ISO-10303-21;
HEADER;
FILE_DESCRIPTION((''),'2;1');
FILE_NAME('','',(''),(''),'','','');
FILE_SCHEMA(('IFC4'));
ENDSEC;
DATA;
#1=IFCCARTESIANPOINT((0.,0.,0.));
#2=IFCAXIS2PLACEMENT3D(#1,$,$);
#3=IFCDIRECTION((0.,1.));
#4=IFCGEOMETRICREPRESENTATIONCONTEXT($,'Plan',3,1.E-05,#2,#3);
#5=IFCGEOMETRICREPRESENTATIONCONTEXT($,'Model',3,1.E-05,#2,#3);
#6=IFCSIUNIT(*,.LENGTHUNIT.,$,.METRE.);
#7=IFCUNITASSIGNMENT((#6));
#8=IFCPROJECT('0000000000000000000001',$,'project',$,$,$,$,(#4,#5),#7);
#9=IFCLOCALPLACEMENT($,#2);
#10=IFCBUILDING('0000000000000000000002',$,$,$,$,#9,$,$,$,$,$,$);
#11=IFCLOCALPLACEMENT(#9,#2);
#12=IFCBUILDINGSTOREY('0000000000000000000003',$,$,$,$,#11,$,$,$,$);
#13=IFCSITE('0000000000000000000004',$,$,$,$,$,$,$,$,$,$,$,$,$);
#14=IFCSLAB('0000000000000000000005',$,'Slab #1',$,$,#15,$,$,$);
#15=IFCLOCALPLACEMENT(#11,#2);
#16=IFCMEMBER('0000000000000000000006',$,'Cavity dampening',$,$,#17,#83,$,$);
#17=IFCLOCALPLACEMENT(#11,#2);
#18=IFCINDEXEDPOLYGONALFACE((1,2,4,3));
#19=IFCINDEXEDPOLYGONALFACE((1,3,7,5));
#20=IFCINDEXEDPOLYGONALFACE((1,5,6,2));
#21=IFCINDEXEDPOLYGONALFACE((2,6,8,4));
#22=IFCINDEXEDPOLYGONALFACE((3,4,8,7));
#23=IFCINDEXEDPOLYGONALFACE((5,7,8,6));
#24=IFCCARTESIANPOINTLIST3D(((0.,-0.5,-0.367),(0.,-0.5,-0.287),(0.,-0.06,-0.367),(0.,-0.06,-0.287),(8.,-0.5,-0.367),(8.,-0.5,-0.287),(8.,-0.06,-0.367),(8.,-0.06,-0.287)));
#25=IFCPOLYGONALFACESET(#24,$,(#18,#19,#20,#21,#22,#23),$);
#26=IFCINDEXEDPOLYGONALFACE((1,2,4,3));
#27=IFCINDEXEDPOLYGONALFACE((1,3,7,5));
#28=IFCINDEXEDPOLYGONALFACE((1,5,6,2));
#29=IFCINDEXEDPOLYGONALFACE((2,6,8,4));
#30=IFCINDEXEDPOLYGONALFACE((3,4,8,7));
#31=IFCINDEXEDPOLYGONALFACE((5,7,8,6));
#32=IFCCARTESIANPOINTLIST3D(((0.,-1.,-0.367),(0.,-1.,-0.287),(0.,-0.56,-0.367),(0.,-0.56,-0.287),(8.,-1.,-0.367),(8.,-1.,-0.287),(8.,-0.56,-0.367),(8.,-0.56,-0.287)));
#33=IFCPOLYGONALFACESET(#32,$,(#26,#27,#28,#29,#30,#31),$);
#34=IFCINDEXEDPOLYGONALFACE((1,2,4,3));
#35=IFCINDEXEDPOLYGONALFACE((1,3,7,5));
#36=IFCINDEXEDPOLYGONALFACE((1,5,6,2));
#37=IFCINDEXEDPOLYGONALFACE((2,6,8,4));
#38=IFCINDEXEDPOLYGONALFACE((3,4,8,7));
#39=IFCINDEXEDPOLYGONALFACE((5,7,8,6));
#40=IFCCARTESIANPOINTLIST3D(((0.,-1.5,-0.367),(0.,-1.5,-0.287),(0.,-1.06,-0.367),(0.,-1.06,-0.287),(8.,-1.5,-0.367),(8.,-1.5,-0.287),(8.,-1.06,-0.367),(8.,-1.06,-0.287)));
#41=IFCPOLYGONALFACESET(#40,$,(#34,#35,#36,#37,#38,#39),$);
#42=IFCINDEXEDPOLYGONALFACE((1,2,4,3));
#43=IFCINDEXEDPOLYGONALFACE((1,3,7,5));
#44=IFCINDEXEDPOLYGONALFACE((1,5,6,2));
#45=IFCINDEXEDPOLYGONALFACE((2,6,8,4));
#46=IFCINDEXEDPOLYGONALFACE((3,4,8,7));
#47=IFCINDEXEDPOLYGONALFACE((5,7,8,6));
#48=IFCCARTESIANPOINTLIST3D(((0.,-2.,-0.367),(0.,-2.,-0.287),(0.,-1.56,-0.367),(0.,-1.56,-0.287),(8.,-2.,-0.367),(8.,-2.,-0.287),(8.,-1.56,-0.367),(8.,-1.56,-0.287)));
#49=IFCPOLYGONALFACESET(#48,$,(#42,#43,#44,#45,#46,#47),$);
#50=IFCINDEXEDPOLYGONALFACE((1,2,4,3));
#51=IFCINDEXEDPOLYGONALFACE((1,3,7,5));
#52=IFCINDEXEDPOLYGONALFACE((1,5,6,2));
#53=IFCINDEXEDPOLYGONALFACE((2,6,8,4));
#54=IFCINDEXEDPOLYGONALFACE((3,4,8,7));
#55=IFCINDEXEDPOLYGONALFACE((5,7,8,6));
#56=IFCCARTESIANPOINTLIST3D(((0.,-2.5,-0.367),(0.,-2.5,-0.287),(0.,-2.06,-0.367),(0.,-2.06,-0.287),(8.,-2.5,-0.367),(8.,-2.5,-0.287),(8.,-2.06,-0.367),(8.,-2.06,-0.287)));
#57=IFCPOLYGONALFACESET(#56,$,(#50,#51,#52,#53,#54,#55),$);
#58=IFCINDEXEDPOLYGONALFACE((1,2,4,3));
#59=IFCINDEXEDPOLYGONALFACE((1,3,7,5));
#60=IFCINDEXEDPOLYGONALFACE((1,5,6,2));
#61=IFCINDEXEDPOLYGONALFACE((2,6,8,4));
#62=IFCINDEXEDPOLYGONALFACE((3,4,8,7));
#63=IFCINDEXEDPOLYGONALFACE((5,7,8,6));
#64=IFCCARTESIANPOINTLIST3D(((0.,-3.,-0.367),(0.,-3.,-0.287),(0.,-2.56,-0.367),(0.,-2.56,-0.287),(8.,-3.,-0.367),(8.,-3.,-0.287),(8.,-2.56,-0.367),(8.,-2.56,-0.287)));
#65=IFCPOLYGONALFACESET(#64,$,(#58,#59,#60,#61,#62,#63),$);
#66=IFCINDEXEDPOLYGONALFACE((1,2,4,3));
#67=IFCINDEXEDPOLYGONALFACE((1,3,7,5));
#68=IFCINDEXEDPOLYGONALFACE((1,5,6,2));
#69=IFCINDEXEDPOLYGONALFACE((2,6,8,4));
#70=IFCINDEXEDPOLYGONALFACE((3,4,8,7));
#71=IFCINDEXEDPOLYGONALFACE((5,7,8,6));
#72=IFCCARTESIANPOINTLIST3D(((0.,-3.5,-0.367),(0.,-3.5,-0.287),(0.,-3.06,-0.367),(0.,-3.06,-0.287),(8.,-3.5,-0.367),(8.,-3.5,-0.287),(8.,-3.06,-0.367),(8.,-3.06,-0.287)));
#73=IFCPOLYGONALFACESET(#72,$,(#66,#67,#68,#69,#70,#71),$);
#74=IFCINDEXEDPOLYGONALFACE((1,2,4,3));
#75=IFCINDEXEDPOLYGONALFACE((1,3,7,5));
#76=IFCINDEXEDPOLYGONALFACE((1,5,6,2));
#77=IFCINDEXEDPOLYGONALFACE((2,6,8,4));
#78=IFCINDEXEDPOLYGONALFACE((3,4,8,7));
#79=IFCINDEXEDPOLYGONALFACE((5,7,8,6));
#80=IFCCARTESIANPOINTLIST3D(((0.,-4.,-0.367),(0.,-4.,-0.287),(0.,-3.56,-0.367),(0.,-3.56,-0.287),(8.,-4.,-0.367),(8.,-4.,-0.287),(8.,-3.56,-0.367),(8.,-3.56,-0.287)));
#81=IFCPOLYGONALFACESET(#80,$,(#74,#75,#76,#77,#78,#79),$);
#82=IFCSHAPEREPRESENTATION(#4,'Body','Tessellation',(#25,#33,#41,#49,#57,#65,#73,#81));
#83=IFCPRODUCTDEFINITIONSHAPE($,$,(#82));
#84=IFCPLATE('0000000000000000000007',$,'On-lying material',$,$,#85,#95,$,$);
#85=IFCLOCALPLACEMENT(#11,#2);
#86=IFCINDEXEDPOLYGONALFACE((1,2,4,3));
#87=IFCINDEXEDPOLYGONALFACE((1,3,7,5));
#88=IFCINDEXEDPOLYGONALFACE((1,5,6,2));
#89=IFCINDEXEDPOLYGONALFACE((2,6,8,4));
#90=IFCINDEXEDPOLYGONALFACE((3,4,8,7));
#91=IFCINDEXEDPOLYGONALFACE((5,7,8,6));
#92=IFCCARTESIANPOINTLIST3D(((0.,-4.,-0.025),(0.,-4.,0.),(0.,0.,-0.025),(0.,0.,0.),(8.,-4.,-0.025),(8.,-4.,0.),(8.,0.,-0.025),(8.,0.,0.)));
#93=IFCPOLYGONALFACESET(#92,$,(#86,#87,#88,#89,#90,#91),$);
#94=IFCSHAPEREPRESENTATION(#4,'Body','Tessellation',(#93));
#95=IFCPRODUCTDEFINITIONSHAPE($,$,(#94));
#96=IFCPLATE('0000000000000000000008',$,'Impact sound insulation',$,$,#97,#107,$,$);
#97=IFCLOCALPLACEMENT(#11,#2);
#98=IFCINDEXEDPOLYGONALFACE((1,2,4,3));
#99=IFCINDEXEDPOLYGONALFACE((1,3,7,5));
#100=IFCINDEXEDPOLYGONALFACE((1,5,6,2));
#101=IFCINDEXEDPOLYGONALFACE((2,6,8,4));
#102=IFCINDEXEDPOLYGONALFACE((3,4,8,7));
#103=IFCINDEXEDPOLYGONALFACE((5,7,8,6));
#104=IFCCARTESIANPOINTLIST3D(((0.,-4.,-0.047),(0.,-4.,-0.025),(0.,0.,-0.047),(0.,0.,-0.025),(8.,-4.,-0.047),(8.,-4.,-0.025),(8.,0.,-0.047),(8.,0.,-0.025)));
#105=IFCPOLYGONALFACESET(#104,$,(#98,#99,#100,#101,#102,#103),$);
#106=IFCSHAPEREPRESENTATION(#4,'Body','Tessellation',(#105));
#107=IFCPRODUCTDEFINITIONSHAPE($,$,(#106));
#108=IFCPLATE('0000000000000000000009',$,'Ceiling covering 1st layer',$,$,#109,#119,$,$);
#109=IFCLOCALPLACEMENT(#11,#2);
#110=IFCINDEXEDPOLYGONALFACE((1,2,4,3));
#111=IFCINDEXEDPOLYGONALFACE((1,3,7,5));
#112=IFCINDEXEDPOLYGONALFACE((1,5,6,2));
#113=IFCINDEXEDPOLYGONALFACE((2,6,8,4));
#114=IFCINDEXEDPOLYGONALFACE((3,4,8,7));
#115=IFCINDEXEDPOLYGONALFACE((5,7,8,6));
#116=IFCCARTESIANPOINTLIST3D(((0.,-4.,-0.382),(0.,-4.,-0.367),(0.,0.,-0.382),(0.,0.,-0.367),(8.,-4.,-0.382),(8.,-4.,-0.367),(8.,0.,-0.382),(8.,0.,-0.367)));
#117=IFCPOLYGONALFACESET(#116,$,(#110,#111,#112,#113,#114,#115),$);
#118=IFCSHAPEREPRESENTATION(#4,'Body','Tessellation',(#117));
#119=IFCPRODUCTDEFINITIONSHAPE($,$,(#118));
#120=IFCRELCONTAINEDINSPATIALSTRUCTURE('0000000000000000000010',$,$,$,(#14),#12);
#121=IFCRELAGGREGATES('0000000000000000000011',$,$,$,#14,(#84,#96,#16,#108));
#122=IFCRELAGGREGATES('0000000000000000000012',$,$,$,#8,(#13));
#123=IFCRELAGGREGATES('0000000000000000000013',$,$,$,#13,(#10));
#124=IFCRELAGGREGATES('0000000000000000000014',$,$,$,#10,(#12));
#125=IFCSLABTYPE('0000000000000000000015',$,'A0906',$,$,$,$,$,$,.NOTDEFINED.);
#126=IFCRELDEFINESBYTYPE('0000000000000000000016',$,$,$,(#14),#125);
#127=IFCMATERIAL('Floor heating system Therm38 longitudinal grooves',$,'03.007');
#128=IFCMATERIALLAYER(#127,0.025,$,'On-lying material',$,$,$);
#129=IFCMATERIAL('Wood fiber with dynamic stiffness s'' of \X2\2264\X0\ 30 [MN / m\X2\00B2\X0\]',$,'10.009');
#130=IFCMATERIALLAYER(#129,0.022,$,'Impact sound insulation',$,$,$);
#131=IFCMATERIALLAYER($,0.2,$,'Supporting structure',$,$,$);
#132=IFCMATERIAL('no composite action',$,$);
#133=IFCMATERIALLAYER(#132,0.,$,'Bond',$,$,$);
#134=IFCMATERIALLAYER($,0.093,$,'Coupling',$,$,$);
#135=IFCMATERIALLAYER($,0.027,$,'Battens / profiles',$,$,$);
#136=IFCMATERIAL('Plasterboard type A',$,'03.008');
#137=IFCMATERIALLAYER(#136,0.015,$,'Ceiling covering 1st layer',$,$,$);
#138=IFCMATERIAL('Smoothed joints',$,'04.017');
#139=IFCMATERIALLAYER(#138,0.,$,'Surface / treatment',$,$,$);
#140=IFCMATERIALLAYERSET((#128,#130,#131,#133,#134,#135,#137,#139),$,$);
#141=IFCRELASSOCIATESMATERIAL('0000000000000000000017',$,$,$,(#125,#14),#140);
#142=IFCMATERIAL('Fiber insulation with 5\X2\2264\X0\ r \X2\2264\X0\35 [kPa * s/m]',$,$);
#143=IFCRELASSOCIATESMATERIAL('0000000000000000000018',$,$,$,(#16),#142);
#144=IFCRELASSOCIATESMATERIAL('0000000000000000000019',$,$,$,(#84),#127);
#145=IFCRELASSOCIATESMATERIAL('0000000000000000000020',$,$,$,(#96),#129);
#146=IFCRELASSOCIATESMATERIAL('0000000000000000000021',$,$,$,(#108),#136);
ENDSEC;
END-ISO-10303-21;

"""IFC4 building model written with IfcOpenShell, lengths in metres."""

from ifc_helpers import new_model, si_unit, direction, frame, frame_2d, origin, origin_with_axes, place, context, project, spatial, rectangle, extrude, material, layer, layer_set, type_object, element, aggregate, save


model = new_model("IFC4")

# Units and contexts
plan_context = context("Plan", 3, precision=1e-05, world=origin(), true_north=direction((0.0, 1.0)))
model_context = context("Model", 3, precision=1e-05, world=origin(), true_north=direction((0.0, 1.0)))
ifc_project = project(units=[si_unit("LENGTHUNIT", "METRE")], contexts=[plan_context, model_context])

# Site, building, storey
site = spatial("IfcSite", under=ifc_project)
building_placement = place(None, origin())
building = spatial("IfcBuilding", under=site, at=building_placement)
storey_placement = place(building_placement, origin())
storey = spatial("IfcBuildingStorey", under=building, at=storey_placement)

# Slab, member, plates
ifc_material_1 = material(Name="Floor heating system Therm38 longitudinal grooves", Category="03.007")
ifc_layer_1 = layer(ifc_material_1, 0.025, Name="On-lying material")
ifc_material_2 = material(Name="Wood fiber with dynamic stiffness s' of ≤ 30 [MN / m²]", Category="10.009")
ifc_layer_2 = layer(ifc_material_2, 0.022, Name="Impact sound insulation")
ifc_layer_3 = layer(None, 0.2, Name="Supporting structure")
ifc_material_3 = material(Name="no composite action")
ifc_layer_4 = layer(ifc_material_3, 0.0, Name="Bond")
ifc_layer_5 = layer(None, 0.093, Name="Coupling")
ifc_layer_6 = layer(None, 0.027, Name="Battens / profiles")
ifc_material_4 = material(Name="Plasterboard type A", Category="03.008")
ifc_layer_7 = layer(ifc_material_4, 0.015, Name="Ceiling covering 1st layer")
ifc_material_5 = material(Name="Smoothed joints", Category="04.017")
ifc_layer_8 = layer(ifc_material_5, 0.0, Name="Surface / treatment")
ifc_layer_set = layer_set([ifc_layer_1, ifc_layer_2, ifc_layer_3, ifc_layer_4, ifc_layer_5, ifc_layer_6, ifc_layer_7, ifc_layer_8])
slab_type = type_object("IfcSlabType", Name="A0906", PredefinedType="NOTDEFINED", material=ifc_layer_set)
slab_placement = place(None, frame((0.0, 0.0, 0.0), z_axis=(0.0, 0.0, -1.0), x_axis=(1.0, 0.0, 0.0)))
slab = element("IfcSlab", 1, at=slab_placement, inside=storey, type_object=slab_type, material=ifc_layer_set, Name="Slab #1")
ifc_material_6 = material(Name="Fiber insulation with 5≤ r ≤35 [kPa * s/m]")
member_1_placement = place(slab_placement, origin())
member_1 = element("IfcMember", 2, at=member_1_placement, material=ifc_material_6, Name="Cavity dampening", context=plan_context, shape_type="SweptSolid", body=[
    extrude(rectangle(XDim=0.44, YDim=0.08, at=frame_2d((0.22, 0.04), x_axis=(1.0, 0.0))), frame((0.0, 0.06, 0.287), z_axis=(1.0, 0.0, 0.0), x_axis=(0.0, 1.0, 0.0)), (0.0, 0.0, 1.0), 8.0),
    extrude(rectangle(XDim=0.44, YDim=0.08, at=frame_2d((0.22, 0.04), x_axis=(1.0, 0.0))), frame((0.0, 0.56, 0.287), z_axis=(1.0, 0.0, 0.0), x_axis=(0.0, 1.0, 0.0)), (0.0, 0.0, 1.0), 8.0),
    extrude(rectangle(XDim=0.44, YDim=0.08, at=frame_2d((0.22, 0.04), x_axis=(1.0, 0.0))), frame((0.0, 1.06, 0.287), z_axis=(1.0, 0.0, 0.0), x_axis=(0.0, 1.0, 0.0)), (0.0, 0.0, 1.0), 8.0),
    extrude(rectangle(XDim=0.44, YDim=0.08, at=frame_2d((0.22, 0.04), x_axis=(1.0, 0.0))), frame((0.0, 1.56, 0.287), z_axis=(1.0, 0.0, 0.0), x_axis=(0.0, 1.0, 0.0)), (0.0, 0.0, 1.0), 8.0),
    extrude(rectangle(XDim=0.44, YDim=0.08, at=frame_2d((0.22, 0.04), x_axis=(1.0, 0.0))), frame((0.0, 2.06, 0.287), z_axis=(1.0, 0.0, 0.0), x_axis=(0.0, 1.0, 0.0)), (0.0, 0.0, 1.0), 8.0),
    extrude(rectangle(XDim=0.44, YDim=0.08, at=frame_2d((0.22, 0.04), x_axis=(1.0, 0.0))), frame((0.0, 2.56, 0.287), z_axis=(1.0, 0.0, 0.0), x_axis=(0.0, 1.0, 0.0)), (0.0, 0.0, 1.0), 8.0),
    extrude(rectangle(XDim=0.44, YDim=0.08, at=frame_2d((0.22, 0.04), x_axis=(1.0, 0.0))), frame((0.0, 3.06, 0.287), z_axis=(1.0, 0.0, 0.0), x_axis=(0.0, 1.0, 0.0)), (0.0, 0.0, 1.0), 8.0),
    extrude(rectangle(XDim=0.44, YDim=0.08, at=frame_2d((0.22, 0.04), x_axis=(1.0, 0.0))), frame((0.0, 3.56, 0.287), z_axis=(1.0, 0.0, 0.0), x_axis=(0.0, 1.0, 0.0)), (0.0, 0.0, 1.0), 8.0),
])
plate_1_placement = place(slab_placement, origin())
plate_1 = element("IfcPlate", 3, at=plate_1_placement, material=ifc_material_1, Name="On-lying material", context=plan_context, shape_type="SweptSolid", body=[
    extrude(rectangle(XDim=8.0, YDim=4.0, at=frame_2d((4.0, 2.0), x_axis=(1.0, 0.0))), origin_with_axes(), (0.0, 0.0, 1.0), 0.025),
])
plate_2_placement = place(slab_placement, origin())
plate_2 = element("IfcPlate", 4, at=plate_2_placement, material=ifc_material_2, Name="Impact sound insulation", context=plan_context, shape_type="SweptSolid", body=[
    extrude(rectangle(XDim=8.0, YDim=4.0, at=frame_2d((4.0, 2.0), x_axis=(1.0, 0.0))), frame((0.0, 0.0, 0.025), z_axis=(0.0, 0.0, 1.0), x_axis=(1.0, 0.0, 0.0)), (0.0, 0.0, 1.0), 0.022),
])
plate_3_placement = place(slab_placement, origin())
plate_3 = element("IfcPlate", 5, at=plate_3_placement, material=ifc_material_4, Name="Ceiling covering 1st layer", context=plan_context, shape_type="SweptSolid", body=[
    extrude(rectangle(XDim=8.0, YDim=4.0, at=frame_2d((4.0, 2.0), x_axis=(1.0, 0.0))), frame((0.0, 0.0, 0.367), z_axis=(0.0, 0.0, 1.0), x_axis=(1.0, 0.0, 0.0)), (0.0, 0.0, 1.0), 0.015),
])
aggregate(slab, [plate_1, plate_2, member_1, plate_3])

save(model, "model.ifc")
